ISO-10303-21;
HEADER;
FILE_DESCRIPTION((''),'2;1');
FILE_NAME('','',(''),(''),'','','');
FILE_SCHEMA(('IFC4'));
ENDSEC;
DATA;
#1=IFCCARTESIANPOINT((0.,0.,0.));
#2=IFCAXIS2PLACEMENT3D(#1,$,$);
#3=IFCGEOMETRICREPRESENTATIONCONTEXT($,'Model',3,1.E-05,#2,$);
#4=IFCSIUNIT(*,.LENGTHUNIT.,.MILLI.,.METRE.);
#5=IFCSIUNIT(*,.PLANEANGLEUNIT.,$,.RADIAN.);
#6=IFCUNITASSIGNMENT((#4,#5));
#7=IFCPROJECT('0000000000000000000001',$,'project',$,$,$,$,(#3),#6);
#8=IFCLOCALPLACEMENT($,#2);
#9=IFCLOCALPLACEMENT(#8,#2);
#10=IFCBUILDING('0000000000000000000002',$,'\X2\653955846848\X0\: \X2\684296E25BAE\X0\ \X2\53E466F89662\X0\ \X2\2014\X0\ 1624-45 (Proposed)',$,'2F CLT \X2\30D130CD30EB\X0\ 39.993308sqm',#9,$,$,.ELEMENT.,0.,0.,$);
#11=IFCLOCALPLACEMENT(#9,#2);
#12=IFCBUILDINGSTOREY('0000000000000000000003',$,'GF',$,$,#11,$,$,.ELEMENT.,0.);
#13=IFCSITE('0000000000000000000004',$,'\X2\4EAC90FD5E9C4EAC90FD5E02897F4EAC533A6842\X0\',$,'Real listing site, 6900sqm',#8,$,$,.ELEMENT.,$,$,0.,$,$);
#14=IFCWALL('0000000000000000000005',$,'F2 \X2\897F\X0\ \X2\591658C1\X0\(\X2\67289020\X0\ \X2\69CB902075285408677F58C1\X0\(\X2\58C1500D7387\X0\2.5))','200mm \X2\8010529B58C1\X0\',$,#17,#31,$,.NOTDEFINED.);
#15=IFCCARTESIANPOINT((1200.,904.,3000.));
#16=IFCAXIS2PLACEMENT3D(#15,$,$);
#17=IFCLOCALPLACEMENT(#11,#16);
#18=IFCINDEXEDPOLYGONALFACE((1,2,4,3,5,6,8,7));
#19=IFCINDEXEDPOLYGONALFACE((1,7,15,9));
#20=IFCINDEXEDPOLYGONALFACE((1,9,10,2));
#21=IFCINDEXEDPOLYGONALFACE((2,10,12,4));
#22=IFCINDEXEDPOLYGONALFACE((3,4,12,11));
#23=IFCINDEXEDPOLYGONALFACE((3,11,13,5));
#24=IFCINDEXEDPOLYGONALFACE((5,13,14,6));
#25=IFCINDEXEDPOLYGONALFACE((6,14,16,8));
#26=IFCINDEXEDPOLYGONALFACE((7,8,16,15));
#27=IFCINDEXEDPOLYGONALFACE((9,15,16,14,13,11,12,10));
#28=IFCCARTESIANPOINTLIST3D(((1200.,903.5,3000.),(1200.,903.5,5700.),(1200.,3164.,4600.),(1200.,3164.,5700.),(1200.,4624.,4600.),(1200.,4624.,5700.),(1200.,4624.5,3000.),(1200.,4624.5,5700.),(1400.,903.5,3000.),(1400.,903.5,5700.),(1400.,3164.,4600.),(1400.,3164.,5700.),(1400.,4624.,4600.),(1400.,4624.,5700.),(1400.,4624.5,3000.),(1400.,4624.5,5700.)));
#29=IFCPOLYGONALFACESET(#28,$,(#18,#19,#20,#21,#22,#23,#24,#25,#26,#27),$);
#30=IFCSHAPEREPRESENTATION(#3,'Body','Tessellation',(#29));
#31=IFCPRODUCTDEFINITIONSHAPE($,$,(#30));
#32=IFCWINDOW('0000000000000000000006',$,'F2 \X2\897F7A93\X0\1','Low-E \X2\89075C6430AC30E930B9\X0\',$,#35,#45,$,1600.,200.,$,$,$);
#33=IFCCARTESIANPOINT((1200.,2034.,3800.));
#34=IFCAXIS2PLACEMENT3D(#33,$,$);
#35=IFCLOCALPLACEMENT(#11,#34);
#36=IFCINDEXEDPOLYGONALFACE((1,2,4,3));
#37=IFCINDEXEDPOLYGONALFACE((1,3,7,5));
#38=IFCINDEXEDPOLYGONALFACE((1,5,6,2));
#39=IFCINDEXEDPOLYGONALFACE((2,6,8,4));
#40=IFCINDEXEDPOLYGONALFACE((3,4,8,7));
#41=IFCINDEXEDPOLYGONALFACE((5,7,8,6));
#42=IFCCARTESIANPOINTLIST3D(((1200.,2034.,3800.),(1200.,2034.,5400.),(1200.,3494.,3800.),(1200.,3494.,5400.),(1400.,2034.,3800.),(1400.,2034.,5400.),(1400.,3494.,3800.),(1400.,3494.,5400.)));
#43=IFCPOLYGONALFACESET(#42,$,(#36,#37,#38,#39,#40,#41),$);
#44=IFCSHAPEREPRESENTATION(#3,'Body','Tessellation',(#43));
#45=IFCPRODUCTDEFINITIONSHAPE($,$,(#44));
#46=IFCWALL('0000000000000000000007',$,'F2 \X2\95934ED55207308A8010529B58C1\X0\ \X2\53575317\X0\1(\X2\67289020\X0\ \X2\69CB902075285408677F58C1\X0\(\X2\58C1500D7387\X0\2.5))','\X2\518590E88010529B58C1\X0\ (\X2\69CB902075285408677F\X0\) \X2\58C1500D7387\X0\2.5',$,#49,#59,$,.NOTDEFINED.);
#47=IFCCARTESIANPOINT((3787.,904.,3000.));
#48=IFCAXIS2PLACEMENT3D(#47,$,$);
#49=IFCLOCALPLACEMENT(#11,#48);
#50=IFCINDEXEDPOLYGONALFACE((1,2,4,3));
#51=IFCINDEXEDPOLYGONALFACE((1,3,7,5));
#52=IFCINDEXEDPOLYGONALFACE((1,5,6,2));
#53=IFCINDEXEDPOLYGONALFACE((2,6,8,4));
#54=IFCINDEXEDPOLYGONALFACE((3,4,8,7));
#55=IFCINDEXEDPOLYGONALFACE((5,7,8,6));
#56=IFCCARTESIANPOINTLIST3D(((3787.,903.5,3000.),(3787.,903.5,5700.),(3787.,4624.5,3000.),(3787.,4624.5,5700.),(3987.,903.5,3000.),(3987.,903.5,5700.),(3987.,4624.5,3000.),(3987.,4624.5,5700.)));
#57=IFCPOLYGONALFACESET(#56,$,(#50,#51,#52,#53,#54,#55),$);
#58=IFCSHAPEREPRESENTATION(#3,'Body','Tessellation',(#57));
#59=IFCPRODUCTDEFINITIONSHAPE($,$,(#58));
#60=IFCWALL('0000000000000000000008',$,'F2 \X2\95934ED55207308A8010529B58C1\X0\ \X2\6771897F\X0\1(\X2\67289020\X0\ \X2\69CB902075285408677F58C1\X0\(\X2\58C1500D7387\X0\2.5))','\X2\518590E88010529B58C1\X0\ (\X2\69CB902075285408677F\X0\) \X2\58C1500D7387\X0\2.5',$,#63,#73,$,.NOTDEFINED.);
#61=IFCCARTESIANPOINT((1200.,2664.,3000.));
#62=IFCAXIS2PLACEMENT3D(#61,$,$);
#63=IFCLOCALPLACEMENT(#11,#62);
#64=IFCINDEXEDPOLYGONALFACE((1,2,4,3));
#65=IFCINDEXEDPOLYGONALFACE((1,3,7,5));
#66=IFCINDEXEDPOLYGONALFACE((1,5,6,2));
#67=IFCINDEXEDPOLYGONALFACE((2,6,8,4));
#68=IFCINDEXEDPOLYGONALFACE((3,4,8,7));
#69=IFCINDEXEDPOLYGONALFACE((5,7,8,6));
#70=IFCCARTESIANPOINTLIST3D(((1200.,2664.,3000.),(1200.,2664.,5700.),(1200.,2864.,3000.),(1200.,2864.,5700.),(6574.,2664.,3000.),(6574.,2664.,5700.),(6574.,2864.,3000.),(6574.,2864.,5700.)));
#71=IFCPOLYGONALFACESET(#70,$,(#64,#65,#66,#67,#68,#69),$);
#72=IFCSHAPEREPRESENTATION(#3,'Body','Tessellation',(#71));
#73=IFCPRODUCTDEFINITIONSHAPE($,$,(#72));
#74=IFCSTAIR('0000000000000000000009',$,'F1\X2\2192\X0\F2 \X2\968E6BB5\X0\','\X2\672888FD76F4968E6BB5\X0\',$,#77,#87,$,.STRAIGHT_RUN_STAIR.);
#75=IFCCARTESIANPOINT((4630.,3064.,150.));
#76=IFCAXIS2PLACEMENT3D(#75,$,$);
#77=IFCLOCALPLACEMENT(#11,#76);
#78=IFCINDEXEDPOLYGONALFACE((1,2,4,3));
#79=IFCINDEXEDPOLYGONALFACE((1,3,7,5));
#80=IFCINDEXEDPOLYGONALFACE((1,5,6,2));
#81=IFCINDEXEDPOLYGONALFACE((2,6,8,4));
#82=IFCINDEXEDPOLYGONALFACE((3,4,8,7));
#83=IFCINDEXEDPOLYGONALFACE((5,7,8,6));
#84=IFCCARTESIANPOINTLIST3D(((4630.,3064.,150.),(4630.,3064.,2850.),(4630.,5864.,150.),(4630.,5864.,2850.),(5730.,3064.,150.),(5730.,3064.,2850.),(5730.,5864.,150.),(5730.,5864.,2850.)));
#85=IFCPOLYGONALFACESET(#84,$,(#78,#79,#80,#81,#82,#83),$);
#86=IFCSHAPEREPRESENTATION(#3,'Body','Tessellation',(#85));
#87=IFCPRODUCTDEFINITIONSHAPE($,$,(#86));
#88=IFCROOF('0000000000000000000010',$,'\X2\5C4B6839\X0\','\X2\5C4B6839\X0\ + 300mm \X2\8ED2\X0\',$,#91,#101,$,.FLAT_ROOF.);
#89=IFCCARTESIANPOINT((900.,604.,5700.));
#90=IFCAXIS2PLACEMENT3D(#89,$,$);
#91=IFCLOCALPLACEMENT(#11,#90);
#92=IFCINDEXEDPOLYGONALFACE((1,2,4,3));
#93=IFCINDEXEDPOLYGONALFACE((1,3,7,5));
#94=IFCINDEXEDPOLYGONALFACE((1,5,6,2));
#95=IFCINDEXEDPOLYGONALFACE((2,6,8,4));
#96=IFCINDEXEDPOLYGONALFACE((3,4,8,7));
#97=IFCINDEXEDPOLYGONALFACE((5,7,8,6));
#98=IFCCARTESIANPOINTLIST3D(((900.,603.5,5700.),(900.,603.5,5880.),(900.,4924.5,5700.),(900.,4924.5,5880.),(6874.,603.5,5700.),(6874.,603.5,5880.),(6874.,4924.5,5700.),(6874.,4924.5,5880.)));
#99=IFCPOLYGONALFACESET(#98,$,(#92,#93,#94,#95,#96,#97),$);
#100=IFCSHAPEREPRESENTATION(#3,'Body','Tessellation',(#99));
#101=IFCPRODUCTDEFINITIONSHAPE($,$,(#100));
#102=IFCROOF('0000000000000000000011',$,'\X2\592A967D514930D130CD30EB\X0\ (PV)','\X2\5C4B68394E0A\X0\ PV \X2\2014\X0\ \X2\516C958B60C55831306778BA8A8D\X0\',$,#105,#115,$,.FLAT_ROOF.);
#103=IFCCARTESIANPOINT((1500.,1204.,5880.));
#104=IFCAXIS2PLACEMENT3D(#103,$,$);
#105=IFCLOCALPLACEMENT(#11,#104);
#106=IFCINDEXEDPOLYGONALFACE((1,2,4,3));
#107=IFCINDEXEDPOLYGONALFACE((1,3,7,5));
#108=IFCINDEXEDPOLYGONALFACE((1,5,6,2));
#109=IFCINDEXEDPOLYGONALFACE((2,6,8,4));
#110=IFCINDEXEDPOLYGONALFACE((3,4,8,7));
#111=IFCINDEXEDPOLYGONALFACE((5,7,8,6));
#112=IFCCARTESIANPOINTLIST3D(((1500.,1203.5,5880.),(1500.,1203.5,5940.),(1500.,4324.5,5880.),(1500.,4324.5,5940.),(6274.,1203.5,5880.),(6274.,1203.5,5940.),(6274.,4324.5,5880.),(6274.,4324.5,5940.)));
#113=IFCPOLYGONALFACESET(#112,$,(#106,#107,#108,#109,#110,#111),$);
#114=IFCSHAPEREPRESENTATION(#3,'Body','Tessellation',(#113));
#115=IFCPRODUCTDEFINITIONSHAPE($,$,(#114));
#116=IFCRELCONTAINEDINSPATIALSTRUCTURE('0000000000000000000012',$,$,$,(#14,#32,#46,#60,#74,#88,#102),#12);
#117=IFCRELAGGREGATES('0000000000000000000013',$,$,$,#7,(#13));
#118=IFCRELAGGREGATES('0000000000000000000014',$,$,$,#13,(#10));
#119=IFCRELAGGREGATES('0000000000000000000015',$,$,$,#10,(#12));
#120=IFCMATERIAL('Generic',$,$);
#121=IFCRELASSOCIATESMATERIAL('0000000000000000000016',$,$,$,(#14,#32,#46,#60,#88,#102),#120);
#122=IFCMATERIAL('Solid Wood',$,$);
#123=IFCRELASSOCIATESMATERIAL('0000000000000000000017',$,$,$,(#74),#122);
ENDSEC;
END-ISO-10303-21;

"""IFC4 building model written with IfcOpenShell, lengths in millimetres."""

from ifc_helpers import new_model, si_unit, frame, frame_2d, origin, place, context, project, spatial, rectangle, extrude, material, element, fill, save


model = new_model("IFC4")

# Units and contexts
model_context = context("Model", 3, precision=1e-05, world=origin())
ifc_project = project(units=[si_unit("LENGTHUNIT", "METRE", prefix="MILLI"), si_unit("PLANEANGLEUNIT", "RADIAN")], contexts=[model_context])

# Site, building, storey
site_placement = place(None, origin())
site = spatial("IfcSite", under=ifc_project, at=site_placement, Name="京都府京都市西京区桂", ObjectType="Real listing site, 6900sqm", CompositionType="ELEMENT", RefElevation=0.0)
building_placement = place(site_placement, origin())
building = spatial("IfcBuilding", under=site, at=building_placement, Name="改善案: 桂離宮 古書院 — 1624-45 (Proposed)", ObjectType="2F CLT パネル 39.993308sqm", CompositionType="ELEMENT", ElevationOfRefHeight=0.0, ElevationOfTerrain=0.0)
storey_placement = place(building_placement, origin())
storey = spatial("IfcBuildingStorey", under=building, at=storey_placement, Name="GF", CompositionType="ELEMENT", Elevation=0.0)

# Shared definitions
ifc_material_1 = material(Name="Generic")

# Shared definitions
ifc_material_2 = material(Name="Solid Wood")

# Wall, opening, window
wall_1_placement = place(storey_placement, frame((1200.0, 904.0, 3000.0)))
wall_1 = element("IfcWall", 1, at=wall_1_placement, inside=storey, material=ifc_material_1, Name="F2 西 外壁(木造 構造用合板壁(壁倍率2.5))", Description="200mm 耐力壁", PredefinedType="NOTDEFINED", context=model_context, shape_type="SweptSolid", body=[
    extrude(rectangle(XDim=200.0, YDim=3721.0, at=frame_2d((100.0, 1860.0))), frame((1200.0, 904.0, 3000.0)), (0.0, 0.0, 1.0), 2700.0),
])
opening_1_placement = place(storey_placement, frame((1200.0, 2034.0, 3800.0)))
opening_1 = element("IfcOpeningElement", 2, at=opening_1_placement, cuts=wall_1, PredefinedType="NOTDEFINED", context=model_context, shape_type="SweptSolid", body=[
    extrude(rectangle(XDim=200.0, YDim=1460.0, at=frame_2d((100.0, 730.0))), frame((1200.0, 2034.0, 3800.0)), (0.0, 0.0, 1.0), 1600.0),
])
window_1_placement = place(storey_placement, frame((1200.0, 2034.0, 3800.0)))
window_1 = element("IfcWindow", 3, at=window_1_placement, inside=storey, material=ifc_material_1, Name="F2 西窓1", Description="Low-E 複層ガラス", OverallHeight=1600.0, OverallWidth=200.0, context=model_context, shape_type="SweptSolid", body=[
    extrude(rectangle(XDim=200.0, YDim=1460.0, at=frame_2d((100.0, 730.0))), frame((1200.0, 2034.0, 3800.0)), (0.0, 0.0, 1.0), 1600.0),
])
fill(opening_1, window_1)

# Walls
wall_2_placement = place(storey_placement, frame((3787.0, 904.0, 3000.0)))
element("IfcWall", 4, at=wall_2_placement, inside=storey, material=ifc_material_1, Name="F2 間仕切り耐力壁 南北1(木造 構造用合板壁(壁倍率2.5))", Description="内部耐力壁 (構造用合板) 壁倍率2.5", PredefinedType="NOTDEFINED", context=model_context, shape_type="SweptSolid", body=[
    extrude(rectangle(XDim=200.0, YDim=3721.0, at=frame_2d((100.0, 1860.0))), frame((3787.0, 904.0, 3000.0)), (0.0, 0.0, 1.0), 2700.0),
])
wall_3_placement = place(storey_placement, frame((1200.0, 2664.0, 3000.0)))
element("IfcWall", 5, at=wall_3_placement, inside=storey, material=ifc_material_1, Name="F2 間仕切り耐力壁 東西1(木造 構造用合板壁(壁倍率2.5))", Description="内部耐力壁 (構造用合板) 壁倍率2.5", PredefinedType="NOTDEFINED", context=model_context, shape_type="SweptSolid", body=[
    extrude(rectangle(XDim=5374.0, YDim=200.0, at=frame_2d((2687.0, 100.0))), frame((1200.0, 2664.0, 3000.0)), (0.0, 0.0, 1.0), 2700.0),
])

# Stair
stair_placement = place(storey_placement, frame((4630.0, 3064.0, 150.0)))
element("IfcStair", 6, at=stair_placement, inside=storey, material=ifc_material_2, Name="F1→F2 階段", Description="木製直階段", PredefinedType="STRAIGHT_RUN_STAIR", context=model_context, shape_type="SweptSolid", body=[
    extrude(rectangle(XDim=1100.0, YDim=2800.0, at=frame_2d((550.0, 1400.0))), frame((4630.0, 3064.0, 150.0)), (0.0, 0.0, 1.0), 2700.0),
])

# Roofs
roof_1_placement = place(storey_placement, frame((900.0, 604.0, 5700.0)))
element("IfcRoof", 7, at=roof_1_placement, inside=storey, material=ifc_material_1, Name="屋根", Description="屋根 + 300mm 軒", PredefinedType="FLAT_ROOF", context=model_context, shape_type="SweptSolid", body=[
    extrude(rectangle(XDim=5974.0, YDim=4321.0, at=frame_2d((2987.0, 2160.0))), frame((900.0, 604.0, 5700.0)), (0.0, 0.0, 1.0), 180.0),
])
roof_2_placement = place(storey_placement, frame((1500.0, 1204.0, 5880.0)))
element("IfcRoof", 8, at=roof_2_placement, inside=storey, material=ifc_material_1, Name="太陽光パネル (PV)", Description="屋根上 PV — 公開情報で確認", PredefinedType="FLAT_ROOF", context=model_context, shape_type="SweptSolid", body=[
    extrude(rectangle(XDim=4774.0, YDim=3121.0, at=frame_2d((2387.0, 1560.0))), frame((1500.0, 1204.0, 5880.0)), (0.0, 0.0, 1.0), 60.0),
])

save(model, "model.ifc")
